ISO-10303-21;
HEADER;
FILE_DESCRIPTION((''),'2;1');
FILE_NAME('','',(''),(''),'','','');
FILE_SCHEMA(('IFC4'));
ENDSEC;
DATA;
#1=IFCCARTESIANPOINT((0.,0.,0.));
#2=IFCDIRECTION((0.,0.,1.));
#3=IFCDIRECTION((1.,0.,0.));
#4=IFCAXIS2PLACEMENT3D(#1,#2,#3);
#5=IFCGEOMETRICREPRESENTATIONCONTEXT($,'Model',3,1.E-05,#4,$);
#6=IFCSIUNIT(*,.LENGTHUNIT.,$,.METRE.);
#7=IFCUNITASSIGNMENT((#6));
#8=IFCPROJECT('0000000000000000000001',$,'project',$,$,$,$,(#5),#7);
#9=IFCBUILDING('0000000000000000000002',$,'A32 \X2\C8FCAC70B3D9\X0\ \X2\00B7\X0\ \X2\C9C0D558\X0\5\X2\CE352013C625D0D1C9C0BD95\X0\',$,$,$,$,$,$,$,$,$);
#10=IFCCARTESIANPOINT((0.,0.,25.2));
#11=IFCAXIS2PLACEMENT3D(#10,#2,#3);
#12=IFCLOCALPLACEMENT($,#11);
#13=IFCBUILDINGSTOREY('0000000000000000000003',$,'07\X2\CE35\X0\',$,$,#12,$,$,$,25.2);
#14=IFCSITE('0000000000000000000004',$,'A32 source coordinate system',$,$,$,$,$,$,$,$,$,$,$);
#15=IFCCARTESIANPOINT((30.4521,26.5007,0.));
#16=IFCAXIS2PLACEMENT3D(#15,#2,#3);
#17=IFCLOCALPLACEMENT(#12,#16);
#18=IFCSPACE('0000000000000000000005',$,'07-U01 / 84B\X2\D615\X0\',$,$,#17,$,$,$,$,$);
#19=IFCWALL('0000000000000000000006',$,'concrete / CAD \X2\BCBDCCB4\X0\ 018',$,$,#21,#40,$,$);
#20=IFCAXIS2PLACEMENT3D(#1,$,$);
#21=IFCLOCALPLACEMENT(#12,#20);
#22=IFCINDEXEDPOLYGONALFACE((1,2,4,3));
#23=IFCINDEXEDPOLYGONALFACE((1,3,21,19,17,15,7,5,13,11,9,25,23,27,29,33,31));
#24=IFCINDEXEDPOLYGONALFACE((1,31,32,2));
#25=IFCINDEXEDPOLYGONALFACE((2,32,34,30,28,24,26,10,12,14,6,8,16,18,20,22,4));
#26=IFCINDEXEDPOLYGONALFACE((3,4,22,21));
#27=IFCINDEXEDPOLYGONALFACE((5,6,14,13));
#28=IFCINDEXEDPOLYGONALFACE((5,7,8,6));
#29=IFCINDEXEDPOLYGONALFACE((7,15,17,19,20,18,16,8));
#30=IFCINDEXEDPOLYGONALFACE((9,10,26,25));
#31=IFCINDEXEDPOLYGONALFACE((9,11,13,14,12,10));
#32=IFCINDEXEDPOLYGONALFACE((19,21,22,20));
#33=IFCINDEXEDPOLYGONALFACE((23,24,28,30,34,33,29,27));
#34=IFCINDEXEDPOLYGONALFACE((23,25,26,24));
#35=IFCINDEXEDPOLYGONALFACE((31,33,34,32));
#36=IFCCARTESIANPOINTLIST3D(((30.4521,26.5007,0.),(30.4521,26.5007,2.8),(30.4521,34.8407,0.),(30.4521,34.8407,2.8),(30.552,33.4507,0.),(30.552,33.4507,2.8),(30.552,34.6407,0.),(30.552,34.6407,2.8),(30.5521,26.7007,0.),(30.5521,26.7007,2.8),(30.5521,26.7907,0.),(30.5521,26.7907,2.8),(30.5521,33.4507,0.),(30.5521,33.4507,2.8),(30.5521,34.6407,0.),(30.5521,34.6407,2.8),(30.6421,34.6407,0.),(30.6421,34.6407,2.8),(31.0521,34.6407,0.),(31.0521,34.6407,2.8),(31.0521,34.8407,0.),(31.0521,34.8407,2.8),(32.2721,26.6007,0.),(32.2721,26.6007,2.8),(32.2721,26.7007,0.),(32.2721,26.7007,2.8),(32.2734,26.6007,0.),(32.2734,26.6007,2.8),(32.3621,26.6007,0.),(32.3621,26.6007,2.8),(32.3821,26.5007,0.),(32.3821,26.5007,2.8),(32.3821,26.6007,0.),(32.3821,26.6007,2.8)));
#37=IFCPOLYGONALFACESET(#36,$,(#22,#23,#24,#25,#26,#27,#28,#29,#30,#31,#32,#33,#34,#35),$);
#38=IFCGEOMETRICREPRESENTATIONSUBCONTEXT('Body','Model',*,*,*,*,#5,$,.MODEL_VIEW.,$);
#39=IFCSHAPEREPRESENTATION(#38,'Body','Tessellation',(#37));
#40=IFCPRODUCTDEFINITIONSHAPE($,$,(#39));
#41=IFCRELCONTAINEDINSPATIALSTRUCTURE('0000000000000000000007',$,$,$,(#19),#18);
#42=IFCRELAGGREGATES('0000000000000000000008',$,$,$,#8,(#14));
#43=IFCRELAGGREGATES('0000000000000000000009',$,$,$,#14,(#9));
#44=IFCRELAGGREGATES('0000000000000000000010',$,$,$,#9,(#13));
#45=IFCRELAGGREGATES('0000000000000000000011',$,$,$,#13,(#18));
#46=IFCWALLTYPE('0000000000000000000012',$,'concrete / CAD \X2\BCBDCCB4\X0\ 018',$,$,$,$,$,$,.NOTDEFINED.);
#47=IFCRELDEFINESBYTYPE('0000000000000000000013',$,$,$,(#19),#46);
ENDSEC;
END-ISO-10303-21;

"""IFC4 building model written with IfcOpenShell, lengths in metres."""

from ifc_helpers import new_model, si_unit, frame, origin, origin_with_axes, place, context, subcontext, project, spatial, polyline, outline, extrude, source, transform, mapped, type_object, type_shapes, element, save


model = new_model("IFC4")

# Units and contexts
model_context = context("Model", 3, precision=1e-05, world=origin_with_axes())
body_context = subcontext(model_context, "Body", "Model", "MODEL_VIEW")
ifc_project = project(units=[si_unit("LENGTHUNIT", "METRE")], contexts=[model_context])

# Site, building, storey, space
site = spatial("IfcSite", under=ifc_project, Name="A32 source coordinate system")
building = spatial("IfcBuilding", under=site, Name="A32 주거동 · 지하5층–옥탑지붕")
storey_placement = place(None, frame((0.0, 0.0, 25.2), z_axis=(0.0, 0.0, 1.0), x_axis=(1.0, 0.0, 0.0)))
storey = spatial("IfcBuildingStorey", under=building, at=storey_placement, Name="07층", Elevation=25.2)
space_1_placement = place(storey_placement, frame((30.4521, 26.5007, 0.0), z_axis=(0.0, 0.0, 1.0), x_axis=(1.0, 0.0, 0.0)))
space_1 = spatial("IfcSpace", under=storey, at=space_1_placement, Name="07-U01 / 84B형")

# Wall
wall_type_1 = type_object("IfcWallType", Name="concrete / CAD 벽체 018", PredefinedType="NOTDEFINED")
shared_shape_1 = source(origin(), body_context, "Body", "SweptSolid", [
    extrude(outline(polyline([(0.6, 8.34), (0.6, 8.14), (0.19, 8.14), (0.1, 8.14), (0.0999, 8.14), (0.0999, 6.95), (0.1, 6.95), (0.1, 0.29), (0.1, 0.2), (1.82, 0.2), (1.82, 0.1), (1.8213, 0.1), (1.91, 0.1), (1.93, 0.1), (1.93, 0.0), (0.0, 0.0), (0.0, 8.34), (-0.35, 8.34), (-0.35, 8.34), (0.6, 8.34)])), origin(), (0.0, 0.0, 1.0), 2.8),
])
type_shapes(wall_type_1, [shared_shape_1])
wall_1_placement = place(space_1_placement, origin_with_axes())
element("IfcWall", 1, at=wall_1_placement, inside=space_1, type_object=wall_type_1, Name="concrete / CAD 벽체 018", context=body_context, shape_type="MappedRepresentation", body=[
    mapped(shared_shape_1, transform((0.0, 0.0, 0.0), scale=1.0)),
])

save(model, "model.ifc")
